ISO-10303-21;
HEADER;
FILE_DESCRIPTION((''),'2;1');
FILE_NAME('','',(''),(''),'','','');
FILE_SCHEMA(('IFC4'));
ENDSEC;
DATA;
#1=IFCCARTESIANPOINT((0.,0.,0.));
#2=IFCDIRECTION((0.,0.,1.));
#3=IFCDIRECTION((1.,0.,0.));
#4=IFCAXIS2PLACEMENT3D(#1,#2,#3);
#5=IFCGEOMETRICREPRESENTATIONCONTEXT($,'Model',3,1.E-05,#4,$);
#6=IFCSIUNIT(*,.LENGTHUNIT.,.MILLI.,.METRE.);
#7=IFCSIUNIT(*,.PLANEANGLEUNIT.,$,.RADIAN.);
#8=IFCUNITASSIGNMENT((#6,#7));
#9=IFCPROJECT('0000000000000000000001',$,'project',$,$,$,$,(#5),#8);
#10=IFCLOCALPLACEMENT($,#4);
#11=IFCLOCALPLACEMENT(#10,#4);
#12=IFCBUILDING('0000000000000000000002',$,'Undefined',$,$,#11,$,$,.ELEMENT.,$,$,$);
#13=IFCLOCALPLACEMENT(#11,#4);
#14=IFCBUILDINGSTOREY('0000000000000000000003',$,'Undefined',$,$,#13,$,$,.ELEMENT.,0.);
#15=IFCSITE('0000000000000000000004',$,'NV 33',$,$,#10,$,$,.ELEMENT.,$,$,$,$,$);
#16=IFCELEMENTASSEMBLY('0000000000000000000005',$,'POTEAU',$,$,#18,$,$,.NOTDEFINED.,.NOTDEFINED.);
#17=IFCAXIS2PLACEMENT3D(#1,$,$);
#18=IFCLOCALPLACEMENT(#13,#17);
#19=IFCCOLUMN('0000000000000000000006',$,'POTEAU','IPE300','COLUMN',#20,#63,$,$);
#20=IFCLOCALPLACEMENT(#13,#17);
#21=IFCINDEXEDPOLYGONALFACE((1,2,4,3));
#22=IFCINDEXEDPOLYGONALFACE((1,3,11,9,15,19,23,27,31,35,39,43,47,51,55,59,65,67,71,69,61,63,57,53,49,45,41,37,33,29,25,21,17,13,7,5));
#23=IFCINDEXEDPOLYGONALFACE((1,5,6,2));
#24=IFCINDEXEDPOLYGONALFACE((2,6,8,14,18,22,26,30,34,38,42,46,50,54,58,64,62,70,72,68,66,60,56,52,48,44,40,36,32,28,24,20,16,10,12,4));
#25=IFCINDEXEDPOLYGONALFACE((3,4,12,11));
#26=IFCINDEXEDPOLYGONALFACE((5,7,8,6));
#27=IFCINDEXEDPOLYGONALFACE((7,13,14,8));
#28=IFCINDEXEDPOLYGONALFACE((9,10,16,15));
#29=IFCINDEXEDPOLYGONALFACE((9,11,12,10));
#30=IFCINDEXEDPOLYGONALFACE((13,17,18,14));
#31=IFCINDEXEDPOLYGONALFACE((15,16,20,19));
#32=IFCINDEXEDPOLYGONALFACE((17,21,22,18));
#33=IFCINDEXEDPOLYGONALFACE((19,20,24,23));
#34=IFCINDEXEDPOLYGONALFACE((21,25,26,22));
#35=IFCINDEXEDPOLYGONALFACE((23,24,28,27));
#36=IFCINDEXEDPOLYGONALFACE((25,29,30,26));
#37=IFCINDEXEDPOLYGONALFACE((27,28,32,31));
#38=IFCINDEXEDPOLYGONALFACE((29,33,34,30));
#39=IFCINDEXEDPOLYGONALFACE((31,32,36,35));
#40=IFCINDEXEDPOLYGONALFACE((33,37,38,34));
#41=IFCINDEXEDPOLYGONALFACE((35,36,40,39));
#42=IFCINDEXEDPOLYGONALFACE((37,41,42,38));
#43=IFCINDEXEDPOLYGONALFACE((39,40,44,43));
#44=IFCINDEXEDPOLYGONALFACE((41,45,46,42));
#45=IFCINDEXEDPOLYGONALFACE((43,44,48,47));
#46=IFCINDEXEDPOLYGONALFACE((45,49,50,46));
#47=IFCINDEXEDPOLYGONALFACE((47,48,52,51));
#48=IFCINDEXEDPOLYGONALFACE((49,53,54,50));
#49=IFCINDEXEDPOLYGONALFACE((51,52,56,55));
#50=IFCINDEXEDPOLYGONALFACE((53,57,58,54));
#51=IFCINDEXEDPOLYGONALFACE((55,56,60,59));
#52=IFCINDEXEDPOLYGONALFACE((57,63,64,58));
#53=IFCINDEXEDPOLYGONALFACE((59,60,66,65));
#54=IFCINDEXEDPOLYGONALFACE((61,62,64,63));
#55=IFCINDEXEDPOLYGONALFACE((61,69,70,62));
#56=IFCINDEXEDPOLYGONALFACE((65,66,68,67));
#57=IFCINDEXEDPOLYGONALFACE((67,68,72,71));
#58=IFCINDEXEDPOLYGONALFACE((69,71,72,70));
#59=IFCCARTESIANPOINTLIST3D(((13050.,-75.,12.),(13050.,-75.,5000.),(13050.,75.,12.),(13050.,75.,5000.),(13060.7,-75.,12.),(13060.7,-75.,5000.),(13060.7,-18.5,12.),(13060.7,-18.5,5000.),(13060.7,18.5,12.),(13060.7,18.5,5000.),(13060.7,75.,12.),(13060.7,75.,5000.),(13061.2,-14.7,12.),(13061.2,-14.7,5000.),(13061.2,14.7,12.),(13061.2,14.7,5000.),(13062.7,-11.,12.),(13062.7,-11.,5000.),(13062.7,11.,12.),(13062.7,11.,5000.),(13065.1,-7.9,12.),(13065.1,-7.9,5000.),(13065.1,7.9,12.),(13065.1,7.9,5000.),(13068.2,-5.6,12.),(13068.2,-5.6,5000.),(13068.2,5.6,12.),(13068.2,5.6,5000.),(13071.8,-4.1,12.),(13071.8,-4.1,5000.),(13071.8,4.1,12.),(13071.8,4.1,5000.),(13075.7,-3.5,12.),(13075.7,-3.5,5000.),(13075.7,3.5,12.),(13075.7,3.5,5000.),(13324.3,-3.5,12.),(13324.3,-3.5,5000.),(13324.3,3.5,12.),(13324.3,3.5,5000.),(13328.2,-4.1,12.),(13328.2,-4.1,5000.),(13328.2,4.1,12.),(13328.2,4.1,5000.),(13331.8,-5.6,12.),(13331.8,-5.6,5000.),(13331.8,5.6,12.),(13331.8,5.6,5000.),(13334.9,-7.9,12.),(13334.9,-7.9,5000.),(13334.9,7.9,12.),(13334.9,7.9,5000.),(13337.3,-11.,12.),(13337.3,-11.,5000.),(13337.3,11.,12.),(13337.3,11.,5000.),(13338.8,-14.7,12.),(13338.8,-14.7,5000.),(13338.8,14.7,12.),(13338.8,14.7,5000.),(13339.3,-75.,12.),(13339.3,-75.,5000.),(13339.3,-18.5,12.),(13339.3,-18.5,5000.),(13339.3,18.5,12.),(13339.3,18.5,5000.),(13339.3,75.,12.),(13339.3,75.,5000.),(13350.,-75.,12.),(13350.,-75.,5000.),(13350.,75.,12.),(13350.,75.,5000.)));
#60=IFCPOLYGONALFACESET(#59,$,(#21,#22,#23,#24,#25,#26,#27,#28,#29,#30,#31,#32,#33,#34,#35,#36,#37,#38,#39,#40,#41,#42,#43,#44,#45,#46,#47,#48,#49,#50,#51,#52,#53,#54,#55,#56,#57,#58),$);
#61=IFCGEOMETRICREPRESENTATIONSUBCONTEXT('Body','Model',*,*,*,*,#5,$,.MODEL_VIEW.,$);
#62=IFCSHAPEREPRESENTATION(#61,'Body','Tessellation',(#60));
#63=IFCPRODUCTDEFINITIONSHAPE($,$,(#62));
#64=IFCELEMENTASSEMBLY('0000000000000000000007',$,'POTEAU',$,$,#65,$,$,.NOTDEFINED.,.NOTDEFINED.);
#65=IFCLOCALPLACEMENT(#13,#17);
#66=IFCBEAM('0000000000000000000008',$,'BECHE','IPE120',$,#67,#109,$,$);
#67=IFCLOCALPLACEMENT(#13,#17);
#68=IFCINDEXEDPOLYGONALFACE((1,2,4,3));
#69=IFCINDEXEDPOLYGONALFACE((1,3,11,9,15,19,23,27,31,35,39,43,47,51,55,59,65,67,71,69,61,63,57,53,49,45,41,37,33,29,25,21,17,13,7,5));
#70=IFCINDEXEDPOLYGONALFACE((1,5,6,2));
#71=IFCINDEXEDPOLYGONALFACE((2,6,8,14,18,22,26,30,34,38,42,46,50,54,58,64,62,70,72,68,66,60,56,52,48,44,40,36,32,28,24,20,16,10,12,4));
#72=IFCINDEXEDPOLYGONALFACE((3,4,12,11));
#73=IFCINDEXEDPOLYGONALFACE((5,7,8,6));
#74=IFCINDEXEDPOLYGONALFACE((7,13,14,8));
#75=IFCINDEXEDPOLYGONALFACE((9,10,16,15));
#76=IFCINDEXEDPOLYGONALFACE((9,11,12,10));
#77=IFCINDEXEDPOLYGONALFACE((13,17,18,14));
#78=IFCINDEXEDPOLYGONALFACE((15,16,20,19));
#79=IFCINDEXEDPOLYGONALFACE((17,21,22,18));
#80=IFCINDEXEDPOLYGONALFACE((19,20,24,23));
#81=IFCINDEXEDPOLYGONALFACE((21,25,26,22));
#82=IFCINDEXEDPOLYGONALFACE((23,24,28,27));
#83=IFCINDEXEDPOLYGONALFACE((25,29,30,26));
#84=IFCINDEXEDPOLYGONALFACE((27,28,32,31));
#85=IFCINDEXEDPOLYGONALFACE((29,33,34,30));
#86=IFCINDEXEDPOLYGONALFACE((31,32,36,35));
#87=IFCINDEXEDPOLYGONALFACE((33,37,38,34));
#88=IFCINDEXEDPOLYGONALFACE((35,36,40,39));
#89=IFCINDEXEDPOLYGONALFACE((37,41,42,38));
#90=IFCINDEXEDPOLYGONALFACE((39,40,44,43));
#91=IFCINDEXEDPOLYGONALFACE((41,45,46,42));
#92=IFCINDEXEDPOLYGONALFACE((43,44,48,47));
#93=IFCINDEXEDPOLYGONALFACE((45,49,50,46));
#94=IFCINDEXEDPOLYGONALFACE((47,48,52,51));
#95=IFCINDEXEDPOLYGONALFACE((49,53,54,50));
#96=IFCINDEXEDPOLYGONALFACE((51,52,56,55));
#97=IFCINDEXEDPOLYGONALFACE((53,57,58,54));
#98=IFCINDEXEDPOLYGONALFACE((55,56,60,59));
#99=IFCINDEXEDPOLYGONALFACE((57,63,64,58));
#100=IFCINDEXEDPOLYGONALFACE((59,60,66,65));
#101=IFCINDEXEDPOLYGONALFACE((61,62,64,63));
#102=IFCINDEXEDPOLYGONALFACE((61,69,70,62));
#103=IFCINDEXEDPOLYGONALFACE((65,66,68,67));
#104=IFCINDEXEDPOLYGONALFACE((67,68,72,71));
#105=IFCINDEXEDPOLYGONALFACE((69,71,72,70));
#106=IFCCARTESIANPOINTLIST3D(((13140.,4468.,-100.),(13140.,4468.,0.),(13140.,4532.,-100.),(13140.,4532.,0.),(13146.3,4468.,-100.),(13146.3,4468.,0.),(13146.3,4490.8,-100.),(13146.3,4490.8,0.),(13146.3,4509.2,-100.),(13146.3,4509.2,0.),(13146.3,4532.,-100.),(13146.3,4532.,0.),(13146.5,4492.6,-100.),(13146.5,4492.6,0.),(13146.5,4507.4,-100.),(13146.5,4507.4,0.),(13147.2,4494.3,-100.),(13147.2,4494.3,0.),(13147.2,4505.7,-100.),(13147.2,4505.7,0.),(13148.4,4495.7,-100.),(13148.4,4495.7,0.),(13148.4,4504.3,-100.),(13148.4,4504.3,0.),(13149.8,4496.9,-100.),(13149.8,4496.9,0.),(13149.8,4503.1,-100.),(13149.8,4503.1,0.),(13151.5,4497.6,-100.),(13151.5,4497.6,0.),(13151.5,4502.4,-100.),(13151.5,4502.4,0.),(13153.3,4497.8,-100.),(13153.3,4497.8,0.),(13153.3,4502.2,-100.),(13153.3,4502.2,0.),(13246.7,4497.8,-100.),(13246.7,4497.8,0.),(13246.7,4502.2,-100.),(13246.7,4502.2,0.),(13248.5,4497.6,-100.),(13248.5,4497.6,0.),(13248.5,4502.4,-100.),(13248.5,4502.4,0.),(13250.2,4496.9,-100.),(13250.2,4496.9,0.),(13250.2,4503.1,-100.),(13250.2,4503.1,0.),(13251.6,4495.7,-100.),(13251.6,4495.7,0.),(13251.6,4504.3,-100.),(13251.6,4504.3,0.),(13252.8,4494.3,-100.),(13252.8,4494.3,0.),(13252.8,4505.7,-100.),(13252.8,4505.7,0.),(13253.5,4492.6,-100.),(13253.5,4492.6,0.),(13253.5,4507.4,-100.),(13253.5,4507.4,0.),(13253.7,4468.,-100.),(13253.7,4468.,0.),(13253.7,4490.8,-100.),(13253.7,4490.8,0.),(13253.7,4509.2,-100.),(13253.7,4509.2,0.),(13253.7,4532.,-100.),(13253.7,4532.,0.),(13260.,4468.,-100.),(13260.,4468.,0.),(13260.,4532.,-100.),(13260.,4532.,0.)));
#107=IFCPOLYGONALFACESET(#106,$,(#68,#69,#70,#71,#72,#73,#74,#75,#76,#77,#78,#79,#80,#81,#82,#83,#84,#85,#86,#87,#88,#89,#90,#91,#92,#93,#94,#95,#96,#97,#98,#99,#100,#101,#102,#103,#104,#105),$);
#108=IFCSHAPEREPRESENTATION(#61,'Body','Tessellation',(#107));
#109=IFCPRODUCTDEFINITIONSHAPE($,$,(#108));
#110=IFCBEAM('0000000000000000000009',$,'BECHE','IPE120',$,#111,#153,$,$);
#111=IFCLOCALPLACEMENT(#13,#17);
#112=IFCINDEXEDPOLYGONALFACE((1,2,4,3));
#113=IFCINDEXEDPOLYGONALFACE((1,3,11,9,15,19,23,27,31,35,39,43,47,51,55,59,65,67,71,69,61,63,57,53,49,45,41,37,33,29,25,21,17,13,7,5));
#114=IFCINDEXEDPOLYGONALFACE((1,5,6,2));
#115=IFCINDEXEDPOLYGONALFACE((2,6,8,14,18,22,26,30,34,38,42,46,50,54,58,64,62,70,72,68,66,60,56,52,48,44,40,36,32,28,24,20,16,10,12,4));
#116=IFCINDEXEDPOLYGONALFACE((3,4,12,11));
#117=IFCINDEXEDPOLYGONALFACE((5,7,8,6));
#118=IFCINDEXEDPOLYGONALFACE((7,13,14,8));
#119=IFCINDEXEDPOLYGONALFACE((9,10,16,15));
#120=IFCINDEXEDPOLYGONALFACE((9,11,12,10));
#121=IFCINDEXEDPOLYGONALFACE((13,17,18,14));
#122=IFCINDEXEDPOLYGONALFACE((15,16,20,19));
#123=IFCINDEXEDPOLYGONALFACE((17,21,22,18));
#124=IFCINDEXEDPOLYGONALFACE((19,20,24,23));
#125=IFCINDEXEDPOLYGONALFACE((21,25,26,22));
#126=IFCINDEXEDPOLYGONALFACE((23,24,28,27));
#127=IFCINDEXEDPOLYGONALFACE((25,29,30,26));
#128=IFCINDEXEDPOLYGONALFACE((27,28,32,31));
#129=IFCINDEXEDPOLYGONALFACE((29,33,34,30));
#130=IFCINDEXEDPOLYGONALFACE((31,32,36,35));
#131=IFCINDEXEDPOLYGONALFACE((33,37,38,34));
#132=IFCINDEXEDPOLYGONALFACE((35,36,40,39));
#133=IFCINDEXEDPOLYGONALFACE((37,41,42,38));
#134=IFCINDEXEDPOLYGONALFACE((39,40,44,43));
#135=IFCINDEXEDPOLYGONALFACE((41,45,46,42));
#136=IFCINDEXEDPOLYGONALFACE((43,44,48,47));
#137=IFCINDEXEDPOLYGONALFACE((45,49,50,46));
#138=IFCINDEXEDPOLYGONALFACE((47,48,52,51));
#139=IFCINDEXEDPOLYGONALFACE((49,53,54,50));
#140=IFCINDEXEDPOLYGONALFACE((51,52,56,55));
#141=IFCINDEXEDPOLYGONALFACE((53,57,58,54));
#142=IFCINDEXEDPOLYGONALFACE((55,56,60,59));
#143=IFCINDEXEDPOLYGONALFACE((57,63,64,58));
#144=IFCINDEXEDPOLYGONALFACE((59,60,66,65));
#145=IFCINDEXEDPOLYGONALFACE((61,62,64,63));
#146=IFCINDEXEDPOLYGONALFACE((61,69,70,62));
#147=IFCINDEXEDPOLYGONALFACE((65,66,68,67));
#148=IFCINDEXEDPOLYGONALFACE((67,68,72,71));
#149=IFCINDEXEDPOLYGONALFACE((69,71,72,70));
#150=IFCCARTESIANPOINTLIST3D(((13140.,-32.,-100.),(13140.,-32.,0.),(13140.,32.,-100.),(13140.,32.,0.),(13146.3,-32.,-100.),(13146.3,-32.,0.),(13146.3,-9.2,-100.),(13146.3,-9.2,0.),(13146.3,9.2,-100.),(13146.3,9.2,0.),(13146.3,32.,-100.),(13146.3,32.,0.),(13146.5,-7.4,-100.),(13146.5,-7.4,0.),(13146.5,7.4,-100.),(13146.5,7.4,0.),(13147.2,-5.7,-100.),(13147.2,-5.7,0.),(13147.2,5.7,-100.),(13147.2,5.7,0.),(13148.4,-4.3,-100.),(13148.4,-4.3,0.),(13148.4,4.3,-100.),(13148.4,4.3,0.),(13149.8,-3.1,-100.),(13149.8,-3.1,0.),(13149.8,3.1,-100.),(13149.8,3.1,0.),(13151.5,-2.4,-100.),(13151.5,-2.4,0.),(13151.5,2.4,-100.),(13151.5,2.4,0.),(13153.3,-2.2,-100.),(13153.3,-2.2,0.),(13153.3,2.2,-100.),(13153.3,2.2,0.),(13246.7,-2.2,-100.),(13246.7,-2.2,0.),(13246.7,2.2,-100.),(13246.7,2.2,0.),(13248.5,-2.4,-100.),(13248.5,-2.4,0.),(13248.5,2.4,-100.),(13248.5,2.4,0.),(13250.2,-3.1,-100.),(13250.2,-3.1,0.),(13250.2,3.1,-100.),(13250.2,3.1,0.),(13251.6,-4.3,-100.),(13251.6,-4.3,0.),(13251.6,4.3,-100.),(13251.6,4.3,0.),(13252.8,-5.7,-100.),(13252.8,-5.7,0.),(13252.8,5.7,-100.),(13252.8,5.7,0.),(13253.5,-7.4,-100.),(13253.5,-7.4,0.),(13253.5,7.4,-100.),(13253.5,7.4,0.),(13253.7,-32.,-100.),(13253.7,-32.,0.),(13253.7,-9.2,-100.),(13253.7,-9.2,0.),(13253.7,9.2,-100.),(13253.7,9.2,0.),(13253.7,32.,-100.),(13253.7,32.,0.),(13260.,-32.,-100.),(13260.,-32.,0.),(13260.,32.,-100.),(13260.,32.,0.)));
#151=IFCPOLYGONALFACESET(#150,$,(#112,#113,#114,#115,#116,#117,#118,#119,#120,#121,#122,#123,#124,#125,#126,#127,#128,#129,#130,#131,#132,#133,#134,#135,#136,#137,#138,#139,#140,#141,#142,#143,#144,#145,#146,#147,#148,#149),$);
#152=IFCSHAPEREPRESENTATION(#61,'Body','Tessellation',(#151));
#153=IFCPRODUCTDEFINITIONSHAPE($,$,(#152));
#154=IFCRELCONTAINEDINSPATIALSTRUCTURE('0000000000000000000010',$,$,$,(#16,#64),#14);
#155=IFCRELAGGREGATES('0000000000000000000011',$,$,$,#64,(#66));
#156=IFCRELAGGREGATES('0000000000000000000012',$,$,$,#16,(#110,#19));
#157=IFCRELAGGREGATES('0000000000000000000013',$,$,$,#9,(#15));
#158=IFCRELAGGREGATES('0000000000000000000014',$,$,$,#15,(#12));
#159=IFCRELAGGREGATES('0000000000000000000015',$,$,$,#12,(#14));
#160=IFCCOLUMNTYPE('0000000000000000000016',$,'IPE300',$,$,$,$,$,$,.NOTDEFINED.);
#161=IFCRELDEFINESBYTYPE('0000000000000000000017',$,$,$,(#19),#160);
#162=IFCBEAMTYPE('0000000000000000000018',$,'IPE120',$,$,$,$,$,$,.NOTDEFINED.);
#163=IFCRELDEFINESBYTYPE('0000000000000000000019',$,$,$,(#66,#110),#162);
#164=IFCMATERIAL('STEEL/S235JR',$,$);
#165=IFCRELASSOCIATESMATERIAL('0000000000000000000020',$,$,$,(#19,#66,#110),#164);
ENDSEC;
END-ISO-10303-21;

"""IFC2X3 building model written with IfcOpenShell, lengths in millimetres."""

from ifc_helpers import new_model, si_unit, frame, origin_with_axes, origin_2d_with_axis, place, context, subcontext, project, spatial, i_section, extrude, clip, halfspace, material, type_object, element, aggregate, save


model = new_model("IFC2X3")

# Units and contexts
model_context = context("Model", 3, precision=1e-05, world=origin_with_axes())
body_context = subcontext(model_context, "Body", "Model", "MODEL_VIEW")
ifc_project = project(units=[si_unit("LENGTHUNIT", "METRE", prefix="MILLI"), si_unit("PLANEANGLEUNIT", "RADIAN")], contexts=[model_context])

# Site, building, storey
site_placement = place(None, origin_with_axes())
site = spatial("IfcSite", under=ifc_project, at=site_placement, Name="NV 33", CompositionType="ELEMENT")
building_placement = place(site_placement, origin_with_axes())
building = spatial("IfcBuilding", under=site, at=building_placement, Name="Undefined", CompositionType="ELEMENT")
storey_placement = place(building_placement, origin_with_axes())
storey = spatial("IfcBuildingStorey", under=building, at=storey_placement, Name="Undefined", CompositionType="ELEMENT", Elevation=0.0)

# Element assembly, column
assembly_1_placement = place(storey_placement, origin_with_axes())
assembly_1 = element("IfcElementAssembly", 1, at=assembly_1_placement, inside=storey, Name="POTEAU", AssemblyPlace="NOTDEFINED", PredefinedType="NOTDEFINED")
ifc_material_1 = material(Name="STEEL/S235JR")
column_type = type_object("IfcColumnType", Name="IPE300", PredefinedType="NOTDEFINED")
column_placement = place(assembly_1_placement, frame((13200.0, 0.0, 0.0), z_axis=(0.0, 0.0, 1.0), x_axis=(-1.0, 0.0, 0.0)))
column = element("IfcColumn", 2, at=column_placement, type_object=column_type, material=ifc_material_1, Name="POTEAU", Description="IPE300", ObjectType="COLUMN", context=body_context, shape_type="Clipping", body=[
    clip(clip(extrude(i_section(OverallWidth=150.0, OverallDepth=300.0, WebThickness=7.1, FlangeThickness=10.7, FilletRadius=15.0, at=origin_2d_with_axis()), frame((0.0, 0.0, 5000.0), z_axis=(0.0, 0.0, -1.0), x_axis=(0.0, 1.0, 0.0)), (0.0, 0.0, 1.0), 5000.0), halfspace(frame((-150.0, 0.0, 5000.0), z_axis=(0.0, 0.0, -1.0), x_axis=(0.0, -1.0, 0.0)), True)), halfspace(frame((-150.0, 0.0, 12.0), z_axis=(0.0, 0.0, 1.0), x_axis=(0.0, 1.0, 0.0)), True)),
])

# Element assembly, beam
assembly_2_placement = place(storey_placement, origin_with_axes())
assembly_2 = element("IfcElementAssembly", 3, at=assembly_2_placement, inside=storey, Name="POTEAU", AssemblyPlace="NOTDEFINED", PredefinedType="NOTDEFINED")
beam_type_1 = type_object("IfcBeamType", Name="IPE120", PredefinedType="NOTDEFINED")
beam_1_placement = place(assembly_2_placement, frame((13200.0, 4500.0, 0.0), z_axis=(-1.0, 0.0, 0.0), x_axis=(0.0, 0.0, -1.0)))
beam_1 = element("IfcBeam", 4, at=beam_1_placement, type_object=beam_type_1, material=ifc_material_1, Name="BECHE", Description="IPE120", context=body_context, shape_type="SweptSolid", body=[
    extrude(i_section(OverallWidth=64.0, OverallDepth=120.0, WebThickness=4.4, FlangeThickness=6.3, FilletRadius=7.0, at=origin_2d_with_axis()), frame((100.0, 0.0, 0.0), z_axis=(-1.0, 0.0, 0.0), x_axis=(0.0, -1.0, 0.0)), (0.0, 0.0, 1.0), 100.0),
])

# Beam
beam_2_placement = place(assembly_1_placement, frame((13200.0, 0.0, 0.0), z_axis=(-1.0, 0.0, 0.0), x_axis=(0.0, 0.0, -1.0)))
beam_2 = element("IfcBeam", 5, at=beam_2_placement, type_object=beam_type_1, material=ifc_material_1, Name="BECHE", Description="IPE120", context=body_context, shape_type="SweptSolid", body=[
    extrude(i_section(OverallWidth=64.0, OverallDepth=120.0, WebThickness=4.4, FlangeThickness=6.3, FilletRadius=7.0, at=origin_2d_with_axis()), frame((100.0, 0.0, 0.0), z_axis=(-1.0, 0.0, 0.0), x_axis=(0.0, -1.0, 0.0)), (0.0, 0.0, 1.0), 100.0),
])

aggregate(assembly_2, [beam_1])
aggregate(assembly_1, [beam_2, column])

save(model, "model.ifc")
